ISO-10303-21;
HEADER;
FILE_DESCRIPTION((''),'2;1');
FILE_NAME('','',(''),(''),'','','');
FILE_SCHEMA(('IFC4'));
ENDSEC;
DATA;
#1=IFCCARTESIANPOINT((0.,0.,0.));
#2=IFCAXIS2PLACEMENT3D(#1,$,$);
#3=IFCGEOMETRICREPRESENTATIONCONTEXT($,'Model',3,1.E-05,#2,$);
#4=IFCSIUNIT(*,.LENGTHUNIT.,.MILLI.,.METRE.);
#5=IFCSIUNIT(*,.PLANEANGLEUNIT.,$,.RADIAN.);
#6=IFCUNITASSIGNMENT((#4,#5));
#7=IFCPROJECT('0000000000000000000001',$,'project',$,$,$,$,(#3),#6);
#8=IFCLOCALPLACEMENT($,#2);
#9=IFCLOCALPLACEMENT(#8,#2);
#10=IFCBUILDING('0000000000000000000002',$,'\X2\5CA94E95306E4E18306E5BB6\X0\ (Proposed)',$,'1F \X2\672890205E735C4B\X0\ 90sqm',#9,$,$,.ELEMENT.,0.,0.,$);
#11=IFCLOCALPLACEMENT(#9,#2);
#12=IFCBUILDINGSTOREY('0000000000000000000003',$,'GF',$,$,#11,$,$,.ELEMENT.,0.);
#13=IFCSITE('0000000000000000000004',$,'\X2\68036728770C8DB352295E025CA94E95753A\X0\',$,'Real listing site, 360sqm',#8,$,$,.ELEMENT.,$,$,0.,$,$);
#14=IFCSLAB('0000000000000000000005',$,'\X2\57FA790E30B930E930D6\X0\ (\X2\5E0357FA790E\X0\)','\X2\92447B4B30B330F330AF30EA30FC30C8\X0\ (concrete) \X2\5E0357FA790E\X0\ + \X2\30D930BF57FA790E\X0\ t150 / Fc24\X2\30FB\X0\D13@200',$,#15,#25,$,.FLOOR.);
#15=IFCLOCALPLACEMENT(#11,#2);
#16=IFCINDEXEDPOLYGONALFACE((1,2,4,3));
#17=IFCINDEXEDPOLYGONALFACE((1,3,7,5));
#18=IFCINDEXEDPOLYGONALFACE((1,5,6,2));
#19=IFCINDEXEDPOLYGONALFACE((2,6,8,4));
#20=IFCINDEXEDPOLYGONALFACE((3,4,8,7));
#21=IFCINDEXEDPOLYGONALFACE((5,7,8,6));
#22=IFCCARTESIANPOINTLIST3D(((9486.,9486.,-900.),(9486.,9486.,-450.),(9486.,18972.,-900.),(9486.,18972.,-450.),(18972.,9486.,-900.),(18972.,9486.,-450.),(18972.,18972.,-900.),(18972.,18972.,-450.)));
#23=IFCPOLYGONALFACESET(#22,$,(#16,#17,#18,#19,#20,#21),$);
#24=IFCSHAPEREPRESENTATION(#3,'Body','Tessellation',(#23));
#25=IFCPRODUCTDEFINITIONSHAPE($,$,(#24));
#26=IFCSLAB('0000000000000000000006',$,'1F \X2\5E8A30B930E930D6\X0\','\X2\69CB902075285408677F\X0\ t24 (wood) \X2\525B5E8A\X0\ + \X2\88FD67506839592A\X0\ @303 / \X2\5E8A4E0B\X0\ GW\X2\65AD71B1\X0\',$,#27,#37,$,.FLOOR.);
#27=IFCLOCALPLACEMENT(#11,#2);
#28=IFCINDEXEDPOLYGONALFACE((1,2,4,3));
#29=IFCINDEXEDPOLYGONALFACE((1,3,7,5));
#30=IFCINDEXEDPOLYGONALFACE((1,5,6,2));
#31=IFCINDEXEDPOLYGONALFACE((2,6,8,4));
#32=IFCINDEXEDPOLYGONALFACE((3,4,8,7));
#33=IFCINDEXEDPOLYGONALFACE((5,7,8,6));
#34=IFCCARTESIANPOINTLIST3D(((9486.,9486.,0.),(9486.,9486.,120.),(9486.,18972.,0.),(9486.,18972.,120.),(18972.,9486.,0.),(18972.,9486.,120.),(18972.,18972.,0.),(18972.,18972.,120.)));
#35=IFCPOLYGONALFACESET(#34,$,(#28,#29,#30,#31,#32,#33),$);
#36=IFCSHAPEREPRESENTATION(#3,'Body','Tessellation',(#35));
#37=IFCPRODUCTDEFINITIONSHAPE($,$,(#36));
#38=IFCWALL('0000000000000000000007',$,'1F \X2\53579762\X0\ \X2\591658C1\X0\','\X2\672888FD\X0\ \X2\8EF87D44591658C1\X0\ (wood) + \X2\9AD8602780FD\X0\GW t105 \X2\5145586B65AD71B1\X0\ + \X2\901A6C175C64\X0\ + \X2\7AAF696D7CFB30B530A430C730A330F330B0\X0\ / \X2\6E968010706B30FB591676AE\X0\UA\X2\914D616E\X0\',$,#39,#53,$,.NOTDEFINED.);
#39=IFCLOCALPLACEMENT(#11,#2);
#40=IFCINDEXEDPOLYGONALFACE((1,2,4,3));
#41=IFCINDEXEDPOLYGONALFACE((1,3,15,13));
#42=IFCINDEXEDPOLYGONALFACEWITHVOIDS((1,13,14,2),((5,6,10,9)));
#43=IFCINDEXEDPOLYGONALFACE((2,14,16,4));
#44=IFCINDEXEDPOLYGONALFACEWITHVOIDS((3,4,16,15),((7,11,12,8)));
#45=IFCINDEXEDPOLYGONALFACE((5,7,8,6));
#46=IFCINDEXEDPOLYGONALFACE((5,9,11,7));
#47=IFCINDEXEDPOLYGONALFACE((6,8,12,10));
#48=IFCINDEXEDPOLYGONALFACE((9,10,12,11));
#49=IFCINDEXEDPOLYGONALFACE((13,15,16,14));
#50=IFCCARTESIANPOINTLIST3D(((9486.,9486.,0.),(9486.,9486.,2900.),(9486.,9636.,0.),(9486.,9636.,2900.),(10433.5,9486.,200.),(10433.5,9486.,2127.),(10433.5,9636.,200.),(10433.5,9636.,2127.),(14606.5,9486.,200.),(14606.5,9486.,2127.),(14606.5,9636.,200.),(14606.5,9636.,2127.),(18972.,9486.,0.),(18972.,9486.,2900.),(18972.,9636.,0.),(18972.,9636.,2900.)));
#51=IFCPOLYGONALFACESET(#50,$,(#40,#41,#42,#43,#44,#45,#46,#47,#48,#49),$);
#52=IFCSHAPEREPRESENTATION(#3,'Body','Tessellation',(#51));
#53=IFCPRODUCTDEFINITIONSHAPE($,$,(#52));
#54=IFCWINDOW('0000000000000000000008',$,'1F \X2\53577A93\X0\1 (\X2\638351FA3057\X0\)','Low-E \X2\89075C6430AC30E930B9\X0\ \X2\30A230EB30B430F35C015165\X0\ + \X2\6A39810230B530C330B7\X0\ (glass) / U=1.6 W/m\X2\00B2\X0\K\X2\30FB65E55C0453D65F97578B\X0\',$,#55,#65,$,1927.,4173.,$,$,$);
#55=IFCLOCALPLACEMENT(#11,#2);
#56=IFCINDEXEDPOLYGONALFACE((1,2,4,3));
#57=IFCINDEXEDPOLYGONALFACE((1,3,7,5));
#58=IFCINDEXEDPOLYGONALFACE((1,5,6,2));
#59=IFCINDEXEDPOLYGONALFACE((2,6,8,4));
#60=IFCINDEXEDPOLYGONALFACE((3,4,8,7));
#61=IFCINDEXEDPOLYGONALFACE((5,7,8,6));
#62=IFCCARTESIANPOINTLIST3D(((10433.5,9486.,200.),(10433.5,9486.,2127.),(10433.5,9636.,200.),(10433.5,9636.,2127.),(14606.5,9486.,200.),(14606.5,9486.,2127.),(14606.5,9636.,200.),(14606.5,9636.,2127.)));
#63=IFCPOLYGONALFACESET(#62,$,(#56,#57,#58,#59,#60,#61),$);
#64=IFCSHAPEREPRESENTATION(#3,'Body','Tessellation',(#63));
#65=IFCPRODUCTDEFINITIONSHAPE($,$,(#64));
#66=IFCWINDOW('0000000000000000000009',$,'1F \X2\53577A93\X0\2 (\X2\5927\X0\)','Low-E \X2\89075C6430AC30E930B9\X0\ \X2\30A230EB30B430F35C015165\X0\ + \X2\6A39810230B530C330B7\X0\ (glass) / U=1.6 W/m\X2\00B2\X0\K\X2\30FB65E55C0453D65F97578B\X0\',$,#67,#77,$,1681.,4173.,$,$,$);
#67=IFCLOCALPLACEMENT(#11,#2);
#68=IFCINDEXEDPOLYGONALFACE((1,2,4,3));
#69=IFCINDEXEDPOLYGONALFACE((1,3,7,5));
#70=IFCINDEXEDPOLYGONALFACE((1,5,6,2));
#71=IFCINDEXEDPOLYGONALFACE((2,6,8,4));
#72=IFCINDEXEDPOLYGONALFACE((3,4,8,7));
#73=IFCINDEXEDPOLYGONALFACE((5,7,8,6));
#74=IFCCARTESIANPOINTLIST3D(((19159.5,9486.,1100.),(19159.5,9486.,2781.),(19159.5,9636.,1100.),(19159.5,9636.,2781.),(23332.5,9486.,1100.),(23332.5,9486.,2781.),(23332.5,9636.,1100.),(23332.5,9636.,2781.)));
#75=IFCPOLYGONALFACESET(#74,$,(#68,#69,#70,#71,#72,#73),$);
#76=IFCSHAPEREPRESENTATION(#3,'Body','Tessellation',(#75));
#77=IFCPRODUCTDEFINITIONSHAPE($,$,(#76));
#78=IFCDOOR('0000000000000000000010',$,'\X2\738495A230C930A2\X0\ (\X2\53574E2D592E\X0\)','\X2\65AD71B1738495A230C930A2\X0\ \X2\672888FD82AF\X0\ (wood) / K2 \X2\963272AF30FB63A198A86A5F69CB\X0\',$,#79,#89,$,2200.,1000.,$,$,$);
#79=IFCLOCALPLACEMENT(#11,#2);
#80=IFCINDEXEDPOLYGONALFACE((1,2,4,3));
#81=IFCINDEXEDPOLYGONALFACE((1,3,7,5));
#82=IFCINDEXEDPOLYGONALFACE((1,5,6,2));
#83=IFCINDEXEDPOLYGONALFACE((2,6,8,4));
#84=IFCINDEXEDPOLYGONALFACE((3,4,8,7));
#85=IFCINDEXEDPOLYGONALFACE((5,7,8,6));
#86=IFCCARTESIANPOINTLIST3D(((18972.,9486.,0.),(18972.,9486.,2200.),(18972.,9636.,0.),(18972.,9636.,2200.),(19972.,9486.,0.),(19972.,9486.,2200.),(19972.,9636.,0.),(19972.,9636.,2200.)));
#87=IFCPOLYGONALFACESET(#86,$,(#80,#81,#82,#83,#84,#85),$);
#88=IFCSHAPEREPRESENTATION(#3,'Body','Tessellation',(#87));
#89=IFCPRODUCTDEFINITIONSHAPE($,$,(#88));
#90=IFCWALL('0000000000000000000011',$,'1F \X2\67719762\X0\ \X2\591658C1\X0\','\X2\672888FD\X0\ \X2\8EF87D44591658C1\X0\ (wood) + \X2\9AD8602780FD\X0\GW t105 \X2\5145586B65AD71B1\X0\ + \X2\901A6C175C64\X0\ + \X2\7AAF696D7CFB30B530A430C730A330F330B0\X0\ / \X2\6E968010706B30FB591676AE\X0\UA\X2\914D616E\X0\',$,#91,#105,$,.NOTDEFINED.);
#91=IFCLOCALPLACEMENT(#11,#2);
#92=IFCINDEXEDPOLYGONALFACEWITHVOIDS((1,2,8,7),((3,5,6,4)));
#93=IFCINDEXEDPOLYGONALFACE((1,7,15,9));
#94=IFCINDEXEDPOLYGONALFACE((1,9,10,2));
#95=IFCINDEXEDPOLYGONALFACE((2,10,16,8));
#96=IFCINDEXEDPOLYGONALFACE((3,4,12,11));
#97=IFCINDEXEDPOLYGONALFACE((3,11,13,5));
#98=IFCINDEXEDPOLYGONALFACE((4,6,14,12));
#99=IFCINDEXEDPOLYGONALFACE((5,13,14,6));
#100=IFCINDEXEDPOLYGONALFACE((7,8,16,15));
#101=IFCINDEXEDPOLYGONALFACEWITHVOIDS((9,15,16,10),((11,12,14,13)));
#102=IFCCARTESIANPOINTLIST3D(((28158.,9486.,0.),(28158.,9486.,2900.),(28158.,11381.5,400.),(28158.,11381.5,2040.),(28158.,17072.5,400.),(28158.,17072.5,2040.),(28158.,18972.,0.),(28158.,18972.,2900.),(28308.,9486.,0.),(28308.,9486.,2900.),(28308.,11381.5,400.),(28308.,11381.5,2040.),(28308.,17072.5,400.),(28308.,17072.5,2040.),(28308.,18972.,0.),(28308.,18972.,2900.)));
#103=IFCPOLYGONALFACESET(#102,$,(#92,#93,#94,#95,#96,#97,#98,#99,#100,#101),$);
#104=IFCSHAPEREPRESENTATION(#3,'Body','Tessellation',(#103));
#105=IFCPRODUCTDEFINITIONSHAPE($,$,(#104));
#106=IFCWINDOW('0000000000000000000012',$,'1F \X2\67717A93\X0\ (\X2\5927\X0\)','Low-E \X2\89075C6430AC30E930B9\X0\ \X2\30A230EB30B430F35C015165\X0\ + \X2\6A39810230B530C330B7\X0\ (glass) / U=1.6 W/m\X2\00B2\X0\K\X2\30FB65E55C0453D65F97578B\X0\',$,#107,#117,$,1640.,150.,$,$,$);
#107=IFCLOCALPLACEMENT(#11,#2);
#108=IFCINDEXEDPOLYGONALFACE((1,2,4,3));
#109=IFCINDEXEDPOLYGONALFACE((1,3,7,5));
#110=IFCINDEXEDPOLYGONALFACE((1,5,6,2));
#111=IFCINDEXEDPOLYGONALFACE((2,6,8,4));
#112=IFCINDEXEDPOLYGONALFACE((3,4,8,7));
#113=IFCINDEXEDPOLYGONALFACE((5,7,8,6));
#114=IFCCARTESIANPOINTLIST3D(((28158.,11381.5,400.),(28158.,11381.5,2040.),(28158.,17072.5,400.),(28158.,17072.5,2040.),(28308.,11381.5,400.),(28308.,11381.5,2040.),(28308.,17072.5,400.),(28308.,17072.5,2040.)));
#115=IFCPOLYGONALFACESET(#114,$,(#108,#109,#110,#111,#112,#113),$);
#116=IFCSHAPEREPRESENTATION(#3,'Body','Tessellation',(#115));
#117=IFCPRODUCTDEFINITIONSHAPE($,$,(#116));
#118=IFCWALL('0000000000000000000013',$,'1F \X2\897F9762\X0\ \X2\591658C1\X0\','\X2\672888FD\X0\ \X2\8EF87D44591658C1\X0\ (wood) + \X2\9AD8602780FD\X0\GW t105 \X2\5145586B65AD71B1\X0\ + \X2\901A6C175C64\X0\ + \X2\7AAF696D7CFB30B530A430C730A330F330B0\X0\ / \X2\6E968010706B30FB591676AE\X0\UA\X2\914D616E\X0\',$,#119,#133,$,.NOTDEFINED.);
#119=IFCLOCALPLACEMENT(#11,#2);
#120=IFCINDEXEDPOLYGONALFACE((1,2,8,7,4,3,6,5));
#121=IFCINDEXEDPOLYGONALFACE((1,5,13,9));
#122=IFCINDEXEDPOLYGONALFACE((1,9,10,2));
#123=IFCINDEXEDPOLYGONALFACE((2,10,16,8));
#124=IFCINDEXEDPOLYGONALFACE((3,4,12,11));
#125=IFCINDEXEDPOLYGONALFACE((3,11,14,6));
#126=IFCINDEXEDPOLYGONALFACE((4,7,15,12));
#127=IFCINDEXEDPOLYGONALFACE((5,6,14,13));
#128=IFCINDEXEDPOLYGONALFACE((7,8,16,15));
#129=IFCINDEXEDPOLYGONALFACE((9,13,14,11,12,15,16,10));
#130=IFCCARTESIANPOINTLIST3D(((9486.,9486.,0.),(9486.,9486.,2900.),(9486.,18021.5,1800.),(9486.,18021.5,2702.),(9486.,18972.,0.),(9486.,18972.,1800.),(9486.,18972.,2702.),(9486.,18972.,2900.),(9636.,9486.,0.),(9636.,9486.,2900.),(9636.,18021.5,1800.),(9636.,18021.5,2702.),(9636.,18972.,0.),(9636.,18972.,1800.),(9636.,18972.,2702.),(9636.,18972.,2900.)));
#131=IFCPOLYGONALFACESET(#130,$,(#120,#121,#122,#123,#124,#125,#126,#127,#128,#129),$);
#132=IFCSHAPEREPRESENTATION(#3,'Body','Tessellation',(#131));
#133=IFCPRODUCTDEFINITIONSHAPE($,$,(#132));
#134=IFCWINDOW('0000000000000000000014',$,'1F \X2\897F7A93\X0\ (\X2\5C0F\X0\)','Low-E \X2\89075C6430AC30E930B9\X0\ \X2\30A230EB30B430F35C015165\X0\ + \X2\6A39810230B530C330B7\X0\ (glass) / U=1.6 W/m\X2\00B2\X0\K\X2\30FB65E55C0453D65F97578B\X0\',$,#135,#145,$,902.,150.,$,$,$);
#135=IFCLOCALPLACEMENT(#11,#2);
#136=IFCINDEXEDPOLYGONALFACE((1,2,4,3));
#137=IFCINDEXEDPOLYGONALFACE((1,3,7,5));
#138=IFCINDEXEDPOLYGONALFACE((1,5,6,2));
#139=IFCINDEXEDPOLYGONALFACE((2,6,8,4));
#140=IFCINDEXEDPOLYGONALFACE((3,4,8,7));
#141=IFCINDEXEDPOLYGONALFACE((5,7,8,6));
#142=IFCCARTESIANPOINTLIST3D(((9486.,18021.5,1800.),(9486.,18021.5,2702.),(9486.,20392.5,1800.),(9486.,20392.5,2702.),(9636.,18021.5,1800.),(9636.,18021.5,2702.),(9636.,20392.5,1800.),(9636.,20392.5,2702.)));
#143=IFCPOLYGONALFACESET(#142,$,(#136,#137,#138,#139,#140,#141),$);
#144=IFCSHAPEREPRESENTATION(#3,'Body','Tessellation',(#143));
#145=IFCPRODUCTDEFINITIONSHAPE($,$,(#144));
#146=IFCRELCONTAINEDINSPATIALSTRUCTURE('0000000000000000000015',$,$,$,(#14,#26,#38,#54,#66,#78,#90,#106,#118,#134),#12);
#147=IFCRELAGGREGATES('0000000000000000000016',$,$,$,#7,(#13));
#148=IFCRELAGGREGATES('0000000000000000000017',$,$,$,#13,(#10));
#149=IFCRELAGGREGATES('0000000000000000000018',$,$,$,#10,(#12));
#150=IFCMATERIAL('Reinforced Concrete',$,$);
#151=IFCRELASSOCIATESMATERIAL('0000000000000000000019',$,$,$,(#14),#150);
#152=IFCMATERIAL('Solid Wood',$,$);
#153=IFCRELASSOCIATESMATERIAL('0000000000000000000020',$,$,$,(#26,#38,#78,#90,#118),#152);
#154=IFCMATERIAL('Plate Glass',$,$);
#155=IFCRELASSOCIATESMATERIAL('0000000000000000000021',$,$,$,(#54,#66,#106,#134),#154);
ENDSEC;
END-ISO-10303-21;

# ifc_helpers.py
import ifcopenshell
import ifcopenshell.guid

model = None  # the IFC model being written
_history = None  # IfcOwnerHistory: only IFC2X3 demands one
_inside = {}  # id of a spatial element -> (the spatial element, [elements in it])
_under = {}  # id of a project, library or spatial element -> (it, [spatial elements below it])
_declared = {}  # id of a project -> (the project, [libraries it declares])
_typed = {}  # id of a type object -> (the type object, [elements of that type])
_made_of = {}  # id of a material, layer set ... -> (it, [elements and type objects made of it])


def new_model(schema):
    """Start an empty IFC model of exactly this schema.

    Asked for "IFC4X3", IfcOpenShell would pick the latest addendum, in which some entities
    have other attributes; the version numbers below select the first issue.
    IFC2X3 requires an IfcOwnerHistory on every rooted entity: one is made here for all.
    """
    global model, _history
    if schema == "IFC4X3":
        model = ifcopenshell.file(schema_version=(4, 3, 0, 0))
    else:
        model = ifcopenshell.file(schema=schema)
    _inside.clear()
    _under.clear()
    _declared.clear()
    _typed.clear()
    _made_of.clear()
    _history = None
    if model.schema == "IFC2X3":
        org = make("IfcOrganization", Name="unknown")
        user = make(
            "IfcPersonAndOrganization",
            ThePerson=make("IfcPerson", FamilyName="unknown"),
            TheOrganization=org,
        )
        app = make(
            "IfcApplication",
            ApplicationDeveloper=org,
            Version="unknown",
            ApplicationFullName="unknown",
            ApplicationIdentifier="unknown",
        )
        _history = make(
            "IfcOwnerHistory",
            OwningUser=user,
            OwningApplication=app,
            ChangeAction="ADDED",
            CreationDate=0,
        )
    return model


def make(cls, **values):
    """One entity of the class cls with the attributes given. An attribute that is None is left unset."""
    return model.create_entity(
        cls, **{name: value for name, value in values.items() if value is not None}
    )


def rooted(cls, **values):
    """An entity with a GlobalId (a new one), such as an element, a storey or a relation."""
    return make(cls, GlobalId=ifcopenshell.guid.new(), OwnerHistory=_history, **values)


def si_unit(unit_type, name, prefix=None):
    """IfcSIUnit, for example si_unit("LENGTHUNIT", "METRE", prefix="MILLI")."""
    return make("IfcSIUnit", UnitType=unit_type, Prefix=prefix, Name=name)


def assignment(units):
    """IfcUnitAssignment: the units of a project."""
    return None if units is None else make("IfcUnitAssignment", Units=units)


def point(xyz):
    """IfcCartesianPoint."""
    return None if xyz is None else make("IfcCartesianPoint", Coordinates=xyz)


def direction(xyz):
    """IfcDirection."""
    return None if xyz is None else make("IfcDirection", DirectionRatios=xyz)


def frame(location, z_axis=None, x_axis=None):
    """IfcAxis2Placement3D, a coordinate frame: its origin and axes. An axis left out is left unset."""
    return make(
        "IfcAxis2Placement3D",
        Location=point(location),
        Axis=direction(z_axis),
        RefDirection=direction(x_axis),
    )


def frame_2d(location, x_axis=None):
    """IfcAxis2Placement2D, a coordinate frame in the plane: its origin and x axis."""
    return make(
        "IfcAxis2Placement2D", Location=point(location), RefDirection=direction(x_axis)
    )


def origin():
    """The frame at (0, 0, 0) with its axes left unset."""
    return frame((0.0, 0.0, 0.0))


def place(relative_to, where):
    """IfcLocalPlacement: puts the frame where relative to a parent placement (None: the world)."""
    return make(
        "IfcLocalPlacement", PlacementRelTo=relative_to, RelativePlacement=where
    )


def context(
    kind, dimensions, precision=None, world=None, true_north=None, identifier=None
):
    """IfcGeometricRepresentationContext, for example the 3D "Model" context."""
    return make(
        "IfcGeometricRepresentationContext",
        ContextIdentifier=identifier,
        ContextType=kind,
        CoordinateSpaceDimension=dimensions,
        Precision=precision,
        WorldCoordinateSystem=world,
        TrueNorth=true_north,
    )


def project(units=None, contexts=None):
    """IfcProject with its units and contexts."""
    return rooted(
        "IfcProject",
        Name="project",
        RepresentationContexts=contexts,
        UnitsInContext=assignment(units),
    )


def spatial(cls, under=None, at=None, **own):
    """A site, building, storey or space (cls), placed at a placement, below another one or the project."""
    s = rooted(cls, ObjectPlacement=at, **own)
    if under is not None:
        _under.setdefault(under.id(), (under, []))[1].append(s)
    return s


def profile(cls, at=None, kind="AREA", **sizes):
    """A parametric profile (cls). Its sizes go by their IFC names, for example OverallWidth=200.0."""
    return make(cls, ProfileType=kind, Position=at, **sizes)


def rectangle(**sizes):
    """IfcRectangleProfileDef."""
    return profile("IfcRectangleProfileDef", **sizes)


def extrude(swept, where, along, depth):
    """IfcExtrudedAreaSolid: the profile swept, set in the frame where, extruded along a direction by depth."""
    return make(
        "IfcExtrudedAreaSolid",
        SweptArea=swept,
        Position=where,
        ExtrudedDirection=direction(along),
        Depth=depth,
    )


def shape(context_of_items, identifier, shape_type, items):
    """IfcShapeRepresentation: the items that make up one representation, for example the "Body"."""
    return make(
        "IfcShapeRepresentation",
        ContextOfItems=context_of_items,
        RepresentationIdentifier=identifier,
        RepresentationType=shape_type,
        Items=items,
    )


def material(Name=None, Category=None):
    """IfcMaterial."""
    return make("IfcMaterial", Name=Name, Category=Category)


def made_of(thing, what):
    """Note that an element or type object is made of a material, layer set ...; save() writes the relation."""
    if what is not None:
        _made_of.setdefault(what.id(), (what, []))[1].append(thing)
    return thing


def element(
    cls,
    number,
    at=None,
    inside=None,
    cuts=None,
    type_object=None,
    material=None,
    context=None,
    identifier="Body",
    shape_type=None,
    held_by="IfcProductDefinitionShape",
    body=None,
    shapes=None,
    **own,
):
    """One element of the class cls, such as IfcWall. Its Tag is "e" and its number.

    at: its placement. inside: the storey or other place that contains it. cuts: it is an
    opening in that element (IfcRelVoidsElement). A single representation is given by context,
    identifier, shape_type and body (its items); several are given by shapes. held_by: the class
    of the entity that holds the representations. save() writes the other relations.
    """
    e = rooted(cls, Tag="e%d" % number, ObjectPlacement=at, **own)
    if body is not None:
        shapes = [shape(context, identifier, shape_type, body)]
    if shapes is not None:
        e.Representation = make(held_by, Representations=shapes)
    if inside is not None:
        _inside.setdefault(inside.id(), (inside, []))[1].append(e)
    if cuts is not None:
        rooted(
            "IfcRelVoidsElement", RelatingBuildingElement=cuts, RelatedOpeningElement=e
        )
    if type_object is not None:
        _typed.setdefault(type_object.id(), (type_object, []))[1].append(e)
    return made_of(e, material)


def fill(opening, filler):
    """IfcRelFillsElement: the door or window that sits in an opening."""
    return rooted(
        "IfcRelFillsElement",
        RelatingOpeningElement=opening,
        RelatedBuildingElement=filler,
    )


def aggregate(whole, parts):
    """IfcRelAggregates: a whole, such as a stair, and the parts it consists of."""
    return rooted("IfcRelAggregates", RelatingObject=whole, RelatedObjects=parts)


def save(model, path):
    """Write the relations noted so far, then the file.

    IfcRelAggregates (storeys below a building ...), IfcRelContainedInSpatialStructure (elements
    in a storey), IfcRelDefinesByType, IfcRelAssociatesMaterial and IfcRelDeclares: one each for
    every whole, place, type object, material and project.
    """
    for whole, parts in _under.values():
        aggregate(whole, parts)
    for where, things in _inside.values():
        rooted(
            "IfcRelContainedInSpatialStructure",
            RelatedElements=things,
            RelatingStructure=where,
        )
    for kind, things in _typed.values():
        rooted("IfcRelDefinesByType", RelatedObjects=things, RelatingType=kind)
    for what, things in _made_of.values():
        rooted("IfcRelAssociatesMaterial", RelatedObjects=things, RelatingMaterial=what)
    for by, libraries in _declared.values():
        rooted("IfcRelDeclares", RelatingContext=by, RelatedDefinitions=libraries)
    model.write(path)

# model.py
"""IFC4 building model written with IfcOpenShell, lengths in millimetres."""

from ifc_helpers import new_model, si_unit, frame, frame_2d, origin, place, context, project, spatial, rectangle, extrude, material, element, fill, save


model = new_model("IFC4")

# Units and contexts
model_context = context("Model", 3, precision=1e-05, world=origin())
ifc_project = project(units=[si_unit("LENGTHUNIT", "METRE", prefix="MILLI"), si_unit("PLANEANGLEUNIT", "RADIAN")], contexts=[model_context])

# Site, building, storey
site_placement = place(None, origin())
site = spatial("IfcSite", under=ifc_project, at=site_placement, Name="栃木県足利市岩井町", ObjectType="Real listing site, 360sqm", CompositionType="ELEMENT", RefElevation=0.0)
building_placement = place(site_placement, origin())
building = spatial("IfcBuilding", under=site, at=building_placement, Name="岩井の丘の家 (Proposed)", ObjectType="1F 木造平屋 90sqm", CompositionType="ELEMENT", ElevationOfRefHeight=0.0, ElevationOfTerrain=0.0)
storey_placement = place(building_placement, origin())
storey = spatial("IfcBuildingStorey", under=building, at=storey_placement, Name="GF", CompositionType="ELEMENT", Elevation=0.0)

# Slabs
ifc_material_1 = material(Name="Reinforced Concrete")
slab_1_placement = place(storey_placement, frame((4743.0, 4743.0, -450.0)))
element("IfcSlab", 1, at=slab_1_placement, inside=storey, material=ifc_material_1, Name="基礎スラブ (布基礎)", Description="鉄筋コンクリート (concrete) 布基礎 + ベタ基礎 t150 / Fc24・D13@200", PredefinedType="FLOOR", context=model_context, shape_type="SweptSolid", body=[
    extrude(rectangle(XDim=9486.0, YDim=9486.0, at=frame_2d((4743.0, 4743.0))), frame((4743.0, 4743.0, -450.0)), (0.0, 0.0, 1.0), 450.0),
])
ifc_material_2 = material(Name="Solid Wood")
slab_2_placement = place(storey_placement, frame((4743.0, 4743.0, 0.0)))
element("IfcSlab", 2, at=slab_2_placement, inside=storey, material=ifc_material_2, Name="1F 床スラブ", Description="構造用合板 t24 (wood) 剛床 + 製材根太 @303 / 床下 GW断熱", PredefinedType="FLOOR", context=model_context, shape_type="SweptSolid", body=[
    extrude(rectangle(XDim=9486.0, YDim=9486.0, at=frame_2d((4743.0, 4743.0))), frame((4743.0, 4743.0, 0.0)), (0.0, 0.0, 1.0), 120.0),
])

# Wall, openings, windows, door
wall_1_placement = place(storey_placement, frame((4743.0, 4743.0, 0.0)))
wall_1 = element("IfcWall", 3, at=wall_1_placement, inside=storey, material=ifc_material_2, Name="1F 南面 外壁", Description="木製 軸組外壁 (wood) + 高性能GW t105 充填断熱 + 通気層 + 窯業系サイディング / 準耐火・外皮UA配慮", PredefinedType="NOTDEFINED", context=model_context, shape_type="SweptSolid", body=[
    extrude(rectangle(XDim=9486.0, YDim=150.0, at=frame_2d((4743.0, 75.0))), frame((4743.0, 4743.0, 0.0)), (0.0, 0.0, 1.0), 2900.0),
])
opening_1_placement = place(storey_placement, frame((5217.0, 4743.0, 100.0)))
opening_1 = element("IfcOpeningElement", 4, at=opening_1_placement, cuts=wall_1, PredefinedType="NOTDEFINED", context=model_context, shape_type="SweptSolid", body=[
    extrude(rectangle(XDim=4173.0, YDim=150.0, at=frame_2d((2086.0, 75.0))), frame((5217.0, 4743.0, 100.0)), (0.0, 0.0, 1.0), 1927.0),
])
opening_2_placement = place(storey_placement, frame((9580.0, 4743.0, 550.0)))
opening_2 = element("IfcOpeningElement", 5, at=opening_2_placement, cuts=wall_1, PredefinedType="NOTDEFINED", context=model_context, shape_type="SweptSolid", body=[
    extrude(rectangle(XDim=4173.0, YDim=150.0, at=frame_2d((2086.0, 75.0))), frame((9580.0, 4743.0, 550.0)), (0.0, 0.0, 1.0), 1681.0),
])
opening_3_placement = place(storey_placement, frame((9486.0, 4743.0, 0.0)))
opening_3 = element("IfcOpeningElement", 6, at=opening_3_placement, cuts=wall_1, PredefinedType="NOTDEFINED", context=model_context, shape_type="SweptSolid", body=[
    extrude(rectangle(XDim=1000.0, YDim=150.0, at=frame_2d((500.0, 75.0))), frame((9486.0, 4743.0, 0.0)), (0.0, 0.0, 1.0), 2200.0),
])
ifc_material_3 = material(Name="Plate Glass")
window_1_placement = place(storey_placement, frame((5217.0, 4743.0, 100.0)))
window_1 = element("IfcWindow", 7, at=window_1_placement, inside=storey, material=ifc_material_3, Name="1F 南窓1 (掃出し)", Description="Low-E 複層ガラス アルゴン封入 + 樹脂サッシ (glass) / U=1.6 W/m²K・日射取得型", OverallHeight=1927.0, OverallWidth=4173.0, context=model_context, shape_type="SweptSolid", body=[
    extrude(rectangle(XDim=4173.0, YDim=150.0, at=frame_2d((2086.0, 75.0))), frame((5217.0, 4743.0, 100.0)), (0.0, 0.0, 1.0), 1927.0),
])
fill(opening_1, window_1)
window_2_placement = place(storey_placement, frame((9580.0, 4743.0, 550.0)))
window_2 = element("IfcWindow", 8, at=window_2_placement, inside=storey, material=ifc_material_3, Name="1F 南窓2 (大)", Description="Low-E 複層ガラス アルゴン封入 + 樹脂サッシ (glass) / U=1.6 W/m²K・日射取得型", OverallHeight=1681.0, OverallWidth=4173.0, context=model_context, shape_type="SweptSolid", body=[
    extrude(rectangle(XDim=4173.0, YDim=150.0, at=frame_2d((2086.0, 75.0))), frame((9580.0, 4743.0, 550.0)), (0.0, 0.0, 1.0), 1681.0),
])
fill(opening_2, window_2)
door_placement = place(storey_placement, frame((9486.0, 4743.0, 0.0)))
door = element("IfcDoor", 9, at=door_placement, inside=storey, material=ifc_material_2, Name="玄関ドア (南中央)", Description="断熱玄関ドア 木製芯 (wood) / K2 防犯・採風機構", OverallHeight=2200.0, OverallWidth=1000.0, context=model_context, shape_type="SweptSolid", body=[
    extrude(rectangle(XDim=1000.0, YDim=150.0, at=frame_2d((500.0, 75.0))), frame((9486.0, 4743.0, 0.0)), (0.0, 0.0, 1.0), 2200.0),
])
fill(opening_3, door)

# Walls, openings, windows
wall_2_placement = place(storey_placement, frame((14079.0, 4743.0, 0.0)))
wall_2 = element("IfcWall", 10, at=wall_2_placement, inside=storey, material=ifc_material_2, Name="1F 東面 外壁", Description="木製 軸組外壁 (wood) + 高性能GW t105 充填断熱 + 通気層 + 窯業系サイディング / 準耐火・外皮UA配慮", PredefinedType="NOTDEFINED", context=model_context, shape_type="SweptSolid", body=[
    extrude(rectangle(XDim=150.0, YDim=9486.0, at=frame_2d((75.0, 4743.0))), frame((14079.0, 4743.0, 0.0)), (0.0, 0.0, 1.0), 2900.0),
])
opening_4_placement = place(storey_placement, frame((14079.0, 5691.0, 200.0)))
opening_4 = element("IfcOpeningElement", 11, at=opening_4_placement, cuts=wall_2, PredefinedType="NOTDEFINED", context=model_context, shape_type="SweptSolid", body=[
    extrude(rectangle(XDim=150.0, YDim=5691.0, at=frame_2d((75.0, 2845.0))), frame((14079.0, 5691.0, 200.0)), (0.0, 0.0, 1.0), 1640.0),
])
window_3_placement = place(storey_placement, frame((14079.0, 5691.0, 200.0)))
window_3 = element("IfcWindow", 12, at=window_3_placement, inside=storey, material=ifc_material_3, Name="1F 東窓 (大)", Description="Low-E 複層ガラス アルゴン封入 + 樹脂サッシ (glass) / U=1.6 W/m²K・日射取得型", OverallHeight=1640.0, OverallWidth=150.0, context=model_context, shape_type="SweptSolid", body=[
    extrude(rectangle(XDim=150.0, YDim=5691.0, at=frame_2d((75.0, 2845.0))), frame((14079.0, 5691.0, 200.0)), (0.0, 0.0, 1.0), 1640.0),
])
fill(opening_4, window_3)
wall_3_placement = place(storey_placement, frame((4743.0, 4743.0, 0.0)))
wall_3 = element("IfcWall", 13, at=wall_3_placement, inside=storey, material=ifc_material_2, Name="1F 西面 外壁", Description="木製 軸組外壁 (wood) + 高性能GW t105 充填断熱 + 通気層 + 窯業系サイディング / 準耐火・外皮UA配慮", PredefinedType="NOTDEFINED", context=model_context, shape_type="SweptSolid", body=[
    extrude(rectangle(XDim=150.0, YDim=9486.0, at=frame_2d((75.0, 4743.0))), frame((4743.0, 4743.0, 0.0)), (0.0, 0.0, 1.0), 2900.0),
])
opening_5_placement = place(storey_placement, frame((4743.0, 9011.0, 900.0)))
opening_5 = element("IfcOpeningElement", 14, at=opening_5_placement, cuts=wall_3, PredefinedType="NOTDEFINED", context=model_context, shape_type="SweptSolid", body=[
    extrude(rectangle(XDim=150.0, YDim=2371.0, at=frame_2d((75.0, 1185.0))), frame((4743.0, 9011.0, 900.0)), (0.0, 0.0, 1.0), 902.0),
])
window_4_placement = place(storey_placement, frame((4743.0, 9011.0, 900.0)))
window_4 = element("IfcWindow", 15, at=window_4_placement, inside=storey, material=ifc_material_3, Name="1F 西窓 (小)", Description="Low-E 複層ガラス アルゴン封入 + 樹脂サッシ (glass) / U=1.6 W/m²K・日射取得型", OverallHeight=902.0, OverallWidth=150.0, context=model_context, shape_type="SweptSolid", body=[
    extrude(rectangle(XDim=150.0, YDim=2371.0, at=frame_2d((75.0, 1185.0))), frame((4743.0, 9011.0, 900.0)), (0.0, 0.0, 1.0), 902.0),
])
fill(opening_5, window_4)

save(model, "model.ifc")
